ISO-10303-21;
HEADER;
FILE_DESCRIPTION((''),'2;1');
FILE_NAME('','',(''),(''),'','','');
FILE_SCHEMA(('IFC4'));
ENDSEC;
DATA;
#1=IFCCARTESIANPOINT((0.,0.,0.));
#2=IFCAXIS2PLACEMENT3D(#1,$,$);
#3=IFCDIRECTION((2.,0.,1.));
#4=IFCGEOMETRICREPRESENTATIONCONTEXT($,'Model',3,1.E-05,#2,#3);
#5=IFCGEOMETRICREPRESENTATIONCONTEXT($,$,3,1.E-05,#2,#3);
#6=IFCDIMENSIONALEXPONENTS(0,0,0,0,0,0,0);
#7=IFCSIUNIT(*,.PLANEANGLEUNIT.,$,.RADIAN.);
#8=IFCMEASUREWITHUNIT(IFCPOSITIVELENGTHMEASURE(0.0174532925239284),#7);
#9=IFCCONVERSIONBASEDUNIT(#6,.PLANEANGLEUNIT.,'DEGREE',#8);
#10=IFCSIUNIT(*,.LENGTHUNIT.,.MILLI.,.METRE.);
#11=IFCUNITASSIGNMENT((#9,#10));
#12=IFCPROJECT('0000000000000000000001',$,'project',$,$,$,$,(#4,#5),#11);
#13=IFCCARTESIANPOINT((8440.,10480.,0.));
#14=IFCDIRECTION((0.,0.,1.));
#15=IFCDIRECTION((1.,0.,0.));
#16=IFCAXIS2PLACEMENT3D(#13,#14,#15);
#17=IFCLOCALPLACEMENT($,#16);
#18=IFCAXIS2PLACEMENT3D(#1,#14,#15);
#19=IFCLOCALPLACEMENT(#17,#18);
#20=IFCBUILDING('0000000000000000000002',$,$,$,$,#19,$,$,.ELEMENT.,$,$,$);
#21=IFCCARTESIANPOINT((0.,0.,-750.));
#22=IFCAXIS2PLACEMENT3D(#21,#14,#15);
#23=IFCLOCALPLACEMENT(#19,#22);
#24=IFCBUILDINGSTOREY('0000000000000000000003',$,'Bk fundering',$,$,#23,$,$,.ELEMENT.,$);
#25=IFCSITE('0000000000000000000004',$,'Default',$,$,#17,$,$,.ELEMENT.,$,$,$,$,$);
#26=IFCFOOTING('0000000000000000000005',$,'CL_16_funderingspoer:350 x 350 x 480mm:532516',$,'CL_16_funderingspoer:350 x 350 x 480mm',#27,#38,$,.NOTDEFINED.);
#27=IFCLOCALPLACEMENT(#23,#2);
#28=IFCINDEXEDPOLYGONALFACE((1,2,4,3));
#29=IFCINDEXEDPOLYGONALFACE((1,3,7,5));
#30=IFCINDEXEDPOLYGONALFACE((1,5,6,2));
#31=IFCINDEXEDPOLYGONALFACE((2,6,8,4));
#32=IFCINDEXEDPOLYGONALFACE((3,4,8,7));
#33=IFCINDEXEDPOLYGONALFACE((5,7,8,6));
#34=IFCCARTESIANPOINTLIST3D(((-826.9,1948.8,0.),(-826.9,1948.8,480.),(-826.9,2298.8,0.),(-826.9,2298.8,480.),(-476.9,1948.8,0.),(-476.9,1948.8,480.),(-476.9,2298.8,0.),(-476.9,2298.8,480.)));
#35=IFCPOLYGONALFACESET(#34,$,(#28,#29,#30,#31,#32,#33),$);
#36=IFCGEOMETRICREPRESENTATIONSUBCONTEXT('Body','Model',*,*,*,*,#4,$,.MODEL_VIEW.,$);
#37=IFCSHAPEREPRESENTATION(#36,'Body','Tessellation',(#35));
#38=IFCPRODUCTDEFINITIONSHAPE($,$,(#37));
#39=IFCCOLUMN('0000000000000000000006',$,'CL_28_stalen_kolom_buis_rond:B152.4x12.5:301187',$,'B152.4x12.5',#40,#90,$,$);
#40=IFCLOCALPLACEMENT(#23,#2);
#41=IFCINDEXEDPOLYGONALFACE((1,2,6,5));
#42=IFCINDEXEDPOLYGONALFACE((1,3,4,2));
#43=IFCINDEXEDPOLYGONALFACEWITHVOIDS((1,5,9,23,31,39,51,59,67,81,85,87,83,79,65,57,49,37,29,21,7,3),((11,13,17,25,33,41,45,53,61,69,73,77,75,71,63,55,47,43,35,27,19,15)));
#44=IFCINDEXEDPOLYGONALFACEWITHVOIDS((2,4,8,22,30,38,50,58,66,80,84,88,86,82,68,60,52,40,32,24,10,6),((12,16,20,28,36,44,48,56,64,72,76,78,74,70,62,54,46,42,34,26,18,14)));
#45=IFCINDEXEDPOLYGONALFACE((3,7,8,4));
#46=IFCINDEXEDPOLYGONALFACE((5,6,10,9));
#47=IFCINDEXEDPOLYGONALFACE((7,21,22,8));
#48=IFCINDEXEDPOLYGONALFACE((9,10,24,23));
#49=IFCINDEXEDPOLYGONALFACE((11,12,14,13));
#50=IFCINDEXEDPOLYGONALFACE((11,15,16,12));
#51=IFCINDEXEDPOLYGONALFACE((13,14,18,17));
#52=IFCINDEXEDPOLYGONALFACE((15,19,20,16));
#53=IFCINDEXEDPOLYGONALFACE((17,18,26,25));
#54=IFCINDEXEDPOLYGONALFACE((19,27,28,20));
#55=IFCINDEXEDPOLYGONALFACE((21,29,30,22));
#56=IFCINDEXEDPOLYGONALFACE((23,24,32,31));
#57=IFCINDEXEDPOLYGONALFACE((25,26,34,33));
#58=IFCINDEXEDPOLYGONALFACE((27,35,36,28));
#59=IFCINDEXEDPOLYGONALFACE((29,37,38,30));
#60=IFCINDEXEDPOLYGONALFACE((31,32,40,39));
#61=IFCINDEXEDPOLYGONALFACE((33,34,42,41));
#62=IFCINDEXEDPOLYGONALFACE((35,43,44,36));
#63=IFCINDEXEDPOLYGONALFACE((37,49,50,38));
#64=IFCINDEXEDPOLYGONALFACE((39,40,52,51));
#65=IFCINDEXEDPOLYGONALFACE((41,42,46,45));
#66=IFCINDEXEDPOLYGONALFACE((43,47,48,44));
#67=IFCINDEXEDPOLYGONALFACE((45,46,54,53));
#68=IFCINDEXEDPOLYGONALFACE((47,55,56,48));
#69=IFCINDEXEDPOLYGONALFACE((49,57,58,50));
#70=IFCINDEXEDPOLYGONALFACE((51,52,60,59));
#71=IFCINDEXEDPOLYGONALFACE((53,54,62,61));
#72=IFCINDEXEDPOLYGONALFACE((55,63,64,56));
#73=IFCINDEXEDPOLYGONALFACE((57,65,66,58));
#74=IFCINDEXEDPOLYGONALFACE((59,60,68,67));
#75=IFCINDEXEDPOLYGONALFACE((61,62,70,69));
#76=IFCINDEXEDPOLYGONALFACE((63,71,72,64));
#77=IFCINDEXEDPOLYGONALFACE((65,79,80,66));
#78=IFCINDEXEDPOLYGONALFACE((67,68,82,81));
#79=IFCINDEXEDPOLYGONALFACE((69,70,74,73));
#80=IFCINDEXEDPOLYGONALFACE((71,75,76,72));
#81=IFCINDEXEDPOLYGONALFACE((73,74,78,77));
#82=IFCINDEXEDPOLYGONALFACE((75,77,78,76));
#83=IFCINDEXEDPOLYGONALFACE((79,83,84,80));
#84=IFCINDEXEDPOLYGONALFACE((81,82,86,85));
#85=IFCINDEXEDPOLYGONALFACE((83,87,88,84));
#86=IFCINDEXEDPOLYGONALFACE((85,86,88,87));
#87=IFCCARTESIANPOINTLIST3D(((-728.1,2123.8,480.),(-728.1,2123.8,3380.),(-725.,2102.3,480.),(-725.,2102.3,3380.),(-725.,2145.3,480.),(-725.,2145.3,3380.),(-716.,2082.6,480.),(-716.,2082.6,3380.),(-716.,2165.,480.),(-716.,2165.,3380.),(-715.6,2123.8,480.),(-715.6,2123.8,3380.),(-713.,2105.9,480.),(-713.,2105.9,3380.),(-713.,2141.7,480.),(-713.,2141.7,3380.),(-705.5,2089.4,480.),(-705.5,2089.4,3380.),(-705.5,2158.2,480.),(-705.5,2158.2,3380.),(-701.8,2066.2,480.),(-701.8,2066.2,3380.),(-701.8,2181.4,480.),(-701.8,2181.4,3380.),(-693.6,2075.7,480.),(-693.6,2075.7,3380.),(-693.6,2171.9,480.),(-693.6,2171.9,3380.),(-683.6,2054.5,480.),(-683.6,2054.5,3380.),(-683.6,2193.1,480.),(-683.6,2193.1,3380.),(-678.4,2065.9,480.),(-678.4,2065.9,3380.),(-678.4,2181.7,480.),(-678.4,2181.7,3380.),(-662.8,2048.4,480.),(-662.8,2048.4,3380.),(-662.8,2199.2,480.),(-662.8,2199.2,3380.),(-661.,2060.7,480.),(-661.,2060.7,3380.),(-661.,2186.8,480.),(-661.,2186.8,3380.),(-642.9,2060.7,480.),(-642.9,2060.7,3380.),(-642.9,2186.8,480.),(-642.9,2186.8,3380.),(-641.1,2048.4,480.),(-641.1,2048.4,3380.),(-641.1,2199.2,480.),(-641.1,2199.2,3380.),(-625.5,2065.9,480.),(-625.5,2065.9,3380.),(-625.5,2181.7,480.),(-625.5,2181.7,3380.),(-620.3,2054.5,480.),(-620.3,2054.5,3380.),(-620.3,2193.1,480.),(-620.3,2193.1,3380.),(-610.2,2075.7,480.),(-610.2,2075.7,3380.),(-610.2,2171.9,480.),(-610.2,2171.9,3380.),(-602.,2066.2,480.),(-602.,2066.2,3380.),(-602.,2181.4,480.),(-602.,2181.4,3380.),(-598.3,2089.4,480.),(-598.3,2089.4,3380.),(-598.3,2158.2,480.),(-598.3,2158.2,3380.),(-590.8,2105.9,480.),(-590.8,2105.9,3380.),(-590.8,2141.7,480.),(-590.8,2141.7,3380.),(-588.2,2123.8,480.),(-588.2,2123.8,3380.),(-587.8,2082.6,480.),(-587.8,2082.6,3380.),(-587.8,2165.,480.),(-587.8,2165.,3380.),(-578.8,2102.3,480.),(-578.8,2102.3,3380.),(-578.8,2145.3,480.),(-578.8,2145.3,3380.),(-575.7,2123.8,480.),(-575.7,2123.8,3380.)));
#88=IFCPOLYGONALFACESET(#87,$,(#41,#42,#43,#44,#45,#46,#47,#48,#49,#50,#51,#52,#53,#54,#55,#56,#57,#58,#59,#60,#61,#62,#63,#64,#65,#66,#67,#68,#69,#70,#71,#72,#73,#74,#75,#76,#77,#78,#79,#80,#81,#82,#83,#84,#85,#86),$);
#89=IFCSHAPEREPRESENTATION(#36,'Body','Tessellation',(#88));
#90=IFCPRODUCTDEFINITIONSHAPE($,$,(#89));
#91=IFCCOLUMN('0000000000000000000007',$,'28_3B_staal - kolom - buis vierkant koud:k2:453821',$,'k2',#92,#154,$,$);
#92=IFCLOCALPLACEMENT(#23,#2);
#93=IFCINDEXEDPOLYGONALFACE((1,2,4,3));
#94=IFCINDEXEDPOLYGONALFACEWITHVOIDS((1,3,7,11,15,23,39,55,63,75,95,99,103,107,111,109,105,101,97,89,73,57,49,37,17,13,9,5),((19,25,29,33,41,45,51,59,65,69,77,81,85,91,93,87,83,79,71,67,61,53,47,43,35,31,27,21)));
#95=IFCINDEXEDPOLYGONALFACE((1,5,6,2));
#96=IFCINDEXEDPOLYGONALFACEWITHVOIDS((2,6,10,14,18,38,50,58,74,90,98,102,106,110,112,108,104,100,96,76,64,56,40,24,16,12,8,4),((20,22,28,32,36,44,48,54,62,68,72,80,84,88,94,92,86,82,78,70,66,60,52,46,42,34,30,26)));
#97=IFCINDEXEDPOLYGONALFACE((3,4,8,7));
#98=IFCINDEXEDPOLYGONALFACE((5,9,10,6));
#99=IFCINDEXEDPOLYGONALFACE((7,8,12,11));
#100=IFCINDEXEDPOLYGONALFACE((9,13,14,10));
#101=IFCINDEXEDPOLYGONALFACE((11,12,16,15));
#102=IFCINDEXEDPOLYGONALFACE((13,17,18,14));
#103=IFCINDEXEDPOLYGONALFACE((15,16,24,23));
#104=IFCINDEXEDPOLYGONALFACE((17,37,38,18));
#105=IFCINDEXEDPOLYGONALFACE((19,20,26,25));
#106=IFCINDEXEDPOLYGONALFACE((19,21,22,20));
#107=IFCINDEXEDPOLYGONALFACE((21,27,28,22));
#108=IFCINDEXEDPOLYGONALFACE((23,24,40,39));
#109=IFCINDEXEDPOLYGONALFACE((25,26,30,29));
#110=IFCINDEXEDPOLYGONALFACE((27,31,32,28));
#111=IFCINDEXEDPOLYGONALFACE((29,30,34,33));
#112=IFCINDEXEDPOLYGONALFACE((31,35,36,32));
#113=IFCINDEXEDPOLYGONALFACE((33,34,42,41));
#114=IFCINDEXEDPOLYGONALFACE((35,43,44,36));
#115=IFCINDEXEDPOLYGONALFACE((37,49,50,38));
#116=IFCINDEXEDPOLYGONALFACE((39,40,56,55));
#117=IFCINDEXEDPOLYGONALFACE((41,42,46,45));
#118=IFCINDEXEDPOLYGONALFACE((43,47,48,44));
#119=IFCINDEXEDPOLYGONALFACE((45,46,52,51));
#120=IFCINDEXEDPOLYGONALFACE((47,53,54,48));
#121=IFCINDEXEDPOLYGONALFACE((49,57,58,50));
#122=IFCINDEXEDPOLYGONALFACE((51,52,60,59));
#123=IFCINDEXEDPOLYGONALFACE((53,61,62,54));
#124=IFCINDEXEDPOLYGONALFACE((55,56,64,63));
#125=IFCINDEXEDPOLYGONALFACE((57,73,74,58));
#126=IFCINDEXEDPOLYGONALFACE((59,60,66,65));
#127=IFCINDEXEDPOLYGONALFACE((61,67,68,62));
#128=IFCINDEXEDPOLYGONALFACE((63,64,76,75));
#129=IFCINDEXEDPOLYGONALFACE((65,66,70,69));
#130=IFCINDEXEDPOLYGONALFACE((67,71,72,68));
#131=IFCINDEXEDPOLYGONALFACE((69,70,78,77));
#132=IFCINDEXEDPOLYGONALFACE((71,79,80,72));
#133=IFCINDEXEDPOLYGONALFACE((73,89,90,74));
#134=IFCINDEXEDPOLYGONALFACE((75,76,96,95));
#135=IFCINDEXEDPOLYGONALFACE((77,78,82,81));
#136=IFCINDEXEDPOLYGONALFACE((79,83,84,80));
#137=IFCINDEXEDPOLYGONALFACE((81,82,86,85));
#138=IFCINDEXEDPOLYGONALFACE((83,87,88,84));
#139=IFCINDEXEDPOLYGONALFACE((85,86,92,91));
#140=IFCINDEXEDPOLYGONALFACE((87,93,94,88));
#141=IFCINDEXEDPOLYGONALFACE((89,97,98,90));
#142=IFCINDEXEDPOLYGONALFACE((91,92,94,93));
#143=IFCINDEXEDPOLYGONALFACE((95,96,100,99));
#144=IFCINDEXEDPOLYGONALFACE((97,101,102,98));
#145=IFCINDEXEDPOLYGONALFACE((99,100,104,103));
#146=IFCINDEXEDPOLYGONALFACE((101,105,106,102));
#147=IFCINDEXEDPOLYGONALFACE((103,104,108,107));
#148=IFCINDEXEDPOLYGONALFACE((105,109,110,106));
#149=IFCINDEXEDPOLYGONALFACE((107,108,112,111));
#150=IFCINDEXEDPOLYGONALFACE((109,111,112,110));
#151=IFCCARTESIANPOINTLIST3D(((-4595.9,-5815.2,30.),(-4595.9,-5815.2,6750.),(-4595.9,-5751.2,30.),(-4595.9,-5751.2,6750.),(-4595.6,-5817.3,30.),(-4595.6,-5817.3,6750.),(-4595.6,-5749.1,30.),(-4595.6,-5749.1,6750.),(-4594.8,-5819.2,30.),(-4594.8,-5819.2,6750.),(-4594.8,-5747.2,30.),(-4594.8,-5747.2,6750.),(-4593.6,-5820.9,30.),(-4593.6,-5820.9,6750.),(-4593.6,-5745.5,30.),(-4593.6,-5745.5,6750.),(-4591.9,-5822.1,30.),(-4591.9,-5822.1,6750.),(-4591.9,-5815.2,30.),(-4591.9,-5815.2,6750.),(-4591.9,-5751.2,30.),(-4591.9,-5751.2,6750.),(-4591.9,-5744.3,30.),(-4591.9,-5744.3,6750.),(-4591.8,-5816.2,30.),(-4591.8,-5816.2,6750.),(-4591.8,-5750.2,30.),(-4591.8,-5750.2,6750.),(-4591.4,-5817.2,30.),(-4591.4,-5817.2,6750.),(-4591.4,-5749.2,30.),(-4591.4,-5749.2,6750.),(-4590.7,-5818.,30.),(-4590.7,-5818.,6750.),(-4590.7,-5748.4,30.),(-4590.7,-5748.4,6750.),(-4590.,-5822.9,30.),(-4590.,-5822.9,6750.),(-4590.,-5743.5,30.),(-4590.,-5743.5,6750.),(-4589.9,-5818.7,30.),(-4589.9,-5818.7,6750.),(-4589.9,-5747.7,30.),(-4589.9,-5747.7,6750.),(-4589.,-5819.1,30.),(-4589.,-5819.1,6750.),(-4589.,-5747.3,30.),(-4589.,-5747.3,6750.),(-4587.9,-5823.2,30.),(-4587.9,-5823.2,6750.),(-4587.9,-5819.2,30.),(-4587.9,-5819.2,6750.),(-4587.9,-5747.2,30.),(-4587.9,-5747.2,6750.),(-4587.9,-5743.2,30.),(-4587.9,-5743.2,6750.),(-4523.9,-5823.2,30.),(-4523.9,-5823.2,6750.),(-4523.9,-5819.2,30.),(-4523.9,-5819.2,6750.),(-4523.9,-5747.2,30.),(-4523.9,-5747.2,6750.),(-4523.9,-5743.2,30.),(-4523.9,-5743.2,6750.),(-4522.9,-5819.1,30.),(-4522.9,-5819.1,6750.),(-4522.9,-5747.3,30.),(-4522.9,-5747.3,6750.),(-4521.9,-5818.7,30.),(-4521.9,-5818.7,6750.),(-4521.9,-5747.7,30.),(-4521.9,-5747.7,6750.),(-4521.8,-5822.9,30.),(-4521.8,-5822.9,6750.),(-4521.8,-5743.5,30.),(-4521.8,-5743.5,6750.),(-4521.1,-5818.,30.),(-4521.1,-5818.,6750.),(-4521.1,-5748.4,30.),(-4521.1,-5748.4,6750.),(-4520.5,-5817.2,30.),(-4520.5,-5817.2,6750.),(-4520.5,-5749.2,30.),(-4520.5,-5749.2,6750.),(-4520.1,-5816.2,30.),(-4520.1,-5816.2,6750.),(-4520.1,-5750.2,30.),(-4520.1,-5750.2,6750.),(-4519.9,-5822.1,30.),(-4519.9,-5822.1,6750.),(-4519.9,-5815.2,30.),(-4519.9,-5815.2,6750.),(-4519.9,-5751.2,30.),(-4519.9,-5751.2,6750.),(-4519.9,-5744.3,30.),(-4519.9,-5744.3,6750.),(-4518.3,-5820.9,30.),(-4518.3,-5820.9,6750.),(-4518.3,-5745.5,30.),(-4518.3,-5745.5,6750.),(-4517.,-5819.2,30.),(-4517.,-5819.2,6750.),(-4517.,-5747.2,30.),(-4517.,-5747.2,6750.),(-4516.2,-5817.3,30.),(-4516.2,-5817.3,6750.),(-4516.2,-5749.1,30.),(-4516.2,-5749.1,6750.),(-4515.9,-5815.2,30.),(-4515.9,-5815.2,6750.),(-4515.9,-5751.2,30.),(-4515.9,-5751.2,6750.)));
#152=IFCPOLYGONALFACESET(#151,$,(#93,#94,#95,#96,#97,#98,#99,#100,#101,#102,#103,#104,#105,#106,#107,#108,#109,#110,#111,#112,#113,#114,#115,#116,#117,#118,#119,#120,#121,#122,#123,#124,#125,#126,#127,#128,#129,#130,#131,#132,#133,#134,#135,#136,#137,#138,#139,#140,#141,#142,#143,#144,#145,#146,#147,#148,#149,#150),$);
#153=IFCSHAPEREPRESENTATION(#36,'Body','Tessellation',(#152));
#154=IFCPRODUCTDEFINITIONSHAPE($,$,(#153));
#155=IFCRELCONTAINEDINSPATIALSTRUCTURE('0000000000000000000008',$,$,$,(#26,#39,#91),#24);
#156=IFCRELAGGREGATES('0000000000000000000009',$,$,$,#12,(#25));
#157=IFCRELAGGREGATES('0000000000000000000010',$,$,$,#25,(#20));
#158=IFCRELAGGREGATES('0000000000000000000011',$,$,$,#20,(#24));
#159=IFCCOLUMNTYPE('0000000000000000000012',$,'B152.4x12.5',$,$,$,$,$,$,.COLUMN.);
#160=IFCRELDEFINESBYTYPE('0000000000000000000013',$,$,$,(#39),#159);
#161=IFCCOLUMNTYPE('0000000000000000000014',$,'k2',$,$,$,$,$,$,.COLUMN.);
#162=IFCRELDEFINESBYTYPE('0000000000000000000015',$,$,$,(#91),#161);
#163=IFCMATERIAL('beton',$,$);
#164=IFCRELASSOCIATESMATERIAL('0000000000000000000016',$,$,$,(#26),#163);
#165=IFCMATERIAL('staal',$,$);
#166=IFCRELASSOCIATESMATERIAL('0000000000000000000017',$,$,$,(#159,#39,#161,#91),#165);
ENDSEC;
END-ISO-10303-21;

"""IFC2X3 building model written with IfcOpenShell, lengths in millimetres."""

from ifc_helpers import new_model, entity, si_unit, converted_unit, direction, frame, frame_2d, origin, origin_with_axes, place, context, subcontext, project, spatial, polyline, circle_curve, parameter, trimmed, segment, composite_curve, rectangle, outline, extrude, source, transform, mapped, material, type_object, element, save


model = new_model("IFC2X3")

# Units and contexts
model_context = context("Model", 3, precision=1e-05, world=origin(), true_north=direction((2.0, 0.0, 1.0)))
context_of_model = context(None, 3, precision=1e-05, world=origin(), true_north=direction((2.0, 0.0, 1.0)))
body_context = subcontext(model_context, "Body", "Model", "MODEL_VIEW")
ifc_project = project(units=[converted_unit("PLANEANGLEUNIT", "DEGREE", entity("IfcPositiveLengthMeasure", 0.0174532925239284), si_unit("PLANEANGLEUNIT", "RADIAN"), dimensions=[0, 0, 0, 0, 0, 0, 0]), si_unit("LENGTHUNIT", "METRE", prefix="MILLI")], contexts=[model_context, context_of_model])

# Site, building, storey
site_placement = place(None, frame((8440.0, 10480.0, 0.0), z_axis=(0.0, 0.0, 1.0), x_axis=(1.0, 0.0, 0.0)))
site = spatial("IfcSite", under=ifc_project, at=site_placement, Name="Default", CompositionType="ELEMENT")
building_placement = place(site_placement, origin_with_axes())
building = spatial("IfcBuilding", under=site, at=building_placement, CompositionType="ELEMENT")
storey_placement = place(building_placement, frame((0.0, 0.0, -750.0), z_axis=(0.0, 0.0, 1.0), x_axis=(1.0, 0.0, 0.0)))
storey = spatial("IfcBuildingStorey", under=building, at=storey_placement, Name="Bk fundering", CompositionType="ELEMENT")

# Footing
ifc_material_1 = material(Name="beton")
footing_placement = place(storey_placement, origin_with_axes())
element("IfcFooting", 1, at=footing_placement, inside=storey, material=ifc_material_1, Name="CL_16_funderingspoer:350 x 350 x 480mm:532516", ObjectType="CL_16_funderingspoer:350 x 350 x 480mm", PredefinedType="NOTDEFINED", context=body_context, shape_type="SweptSolid", body=[
    extrude(rectangle(XDim=350.0, YDim=350.0, at=frame_2d((0.0, 0.0), x_axis=(1.0, 0.0))), frame((-651.9, 2123.8, 0.0), z_axis=(0.0, 0.0, 1.0), x_axis=(0.0, 1.0, 0.0)), (0.0, 0.0, 1.0), 480.0),
])

# Columns
ifc_material_2 = material(Name="staal")
column_type_1 = type_object("IfcColumnType", Name="B152.4x12.5", PredefinedType="COLUMN", material=ifc_material_2)
shared_shape_1 = source(origin(), body_context, "Body", "SweptSolid", [
    extrude(outline(composite_curve([segment(trimmed(circle_curve(frame_2d((-651.9, 2123.8), x_axis=(1.0, 0.0)), 76.2), [parameter(0.0)], [parameter(180.0)], True, "PARAMETER"), True, "CONTINUOUS"), segment(trimmed(circle_curve(frame_2d((-651.9, 2123.8), x_axis=(1.0, 0.0)), 76.2), [parameter(180.0)], [parameter(0.0)], True, "PARAMETER"), True, "CONTINUOUS")], self_intersect=False), holes=[composite_curve([segment(trimmed(circle_curve(frame_2d((-651.9, 2123.8), x_axis=(1.0, 0.0)), 63.7), [parameter(180.0)], [parameter(0.0)], True, "PARAMETER"), False, "CONTINUOUS"), segment(trimmed(circle_curve(frame_2d((-651.9, 2123.8), x_axis=(1.0, 0.0)), 63.7), [parameter(0.0)], [parameter(180.0)], True, "PARAMETER"), False, "CONTINUOUS")], self_intersect=False)]), origin(), (0.0, 0.0, 1.0), 2900.0),
])
column_1_placement = place(storey_placement, frame((0.0, 0.0, 480.0), z_axis=(0.0, 0.0, 1.0), x_axis=(1.0, 0.0, 0.0)))
element("IfcColumn", 2, at=column_1_placement, inside=storey, type_object=column_type_1, material=ifc_material_2, Name="CL_28_stalen_kolom_buis_rond:B152.4x12.5:301187", ObjectType="B152.4x12.5", context=body_context, shape_type="MappedRepresentation", body=[
    mapped(shared_shape_1, transform((0.0, 0.0, 0.0), scale=1.0)),
])
column_type_2 = type_object("IfcColumnType", Name="k2", PredefinedType="COLUMN", material=ifc_material_2)
shared_shape_2 = source(origin(), body_context, "Body", "SweptSolid", [
    extrude(outline(composite_curve([segment(trimmed(circle_curve(frame_2d((32.0, -32.0), x_axis=(1.0, 0.0)), 8.0), [parameter(270.0)], [parameter(0.0)], True, "PARAMETER"), True, "CONTINUOUS"), segment(polyline([(40.0, -32.0), (40.0, 32.0)]), True, "CONTINUOUS"), segment(trimmed(circle_curve(frame_2d((32.0, 32.0), x_axis=(1.0, 0.0)), 8.0), [parameter(0.0)], [parameter(90.0)], True, "PARAMETER"), True, "CONTINUOUS"), segment(polyline([(32.0, 40.0), (-32.0, 40.0)]), True, "CONTINUOUS"), segment(trimmed(circle_curve(frame_2d((-32.0, 32.0), x_axis=(1.0, 0.0)), 8.0), [parameter(90.0)], [parameter(180.0)], True, "PARAMETER"), True, "CONTINUOUS"), segment(polyline([(-40.0, 32.0), (-40.0, -32.0)]), True, "CONTINUOUS"), segment(trimmed(circle_curve(frame_2d((-32.0, -32.0), x_axis=(1.0, 0.0)), 8.0), [parameter(180.0)], [parameter(270.0)], True, "PARAMETER"), True, "CONTINUOUS"), segment(polyline([(-32.0, -40.0), (32.0, -40.0)]), True, "CONTINUOUS")], self_intersect=False), holes=[composite_curve([segment(polyline([(32.0, -36.0), (-32.0, -36.0)]), True, "CONTINUOUS"), segment(trimmed(circle_curve(frame_2d((-32.0, -32.0), x_axis=(1.0, 0.0)), 4.0), [parameter(180.0)], [parameter(270.0)], True, "PARAMETER"), False, "CONTINUOUS"), segment(polyline([(-36.0, -32.0), (-36.0, 32.0)]), True, "CONTINUOUS"), segment(trimmed(circle_curve(frame_2d((-32.0, 32.0), x_axis=(1.0, 0.0)), 4.0), [parameter(90.0)], [parameter(180.0)], True, "PARAMETER"), False, "CONTINUOUS"), segment(polyline([(-32.0, 36.0), (32.0, 36.0)]), True, "CONTINUOUS"), segment(trimmed(circle_curve(frame_2d((32.0, 32.0), x_axis=(1.0, 0.0)), 4.0), [parameter(360.0)], [parameter(90.0)], True, "PARAMETER"), False, "CONTINUOUS"), segment(polyline([(36.0, 32.0), (36.0, -32.0)]), True, "CONTINUOUS"), segment(trimmed(circle_curve(frame_2d((32.0, -32.0), x_axis=(1.0, 0.0)), 4.0), [parameter(270.0)], [parameter(0.0)], True, "PARAMETER"), False, "CONTINUOUS")], self_intersect=False)]), frame((-4555.9, -5783.2, -720.0)), (0.0, 0.0, 1.0), 6720.0),
])
column_2_placement = place(storey_placement, frame((0.0, 0.0, 750.0), z_axis=(0.0, 0.0, 1.0), x_axis=(1.0, 0.0, 0.0)))
element("IfcColumn", 3, at=column_2_placement, inside=storey, type_object=column_type_2, material=ifc_material_2, Name="28_3B_staal - kolom - buis vierkant koud:k2:453821", ObjectType="k2", context=body_context, shape_type="MappedRepresentation", body=[
    mapped(shared_shape_2, transform((0.0, 0.0, 0.0), scale=1.0)),
])

save(model, "model.ifc")
